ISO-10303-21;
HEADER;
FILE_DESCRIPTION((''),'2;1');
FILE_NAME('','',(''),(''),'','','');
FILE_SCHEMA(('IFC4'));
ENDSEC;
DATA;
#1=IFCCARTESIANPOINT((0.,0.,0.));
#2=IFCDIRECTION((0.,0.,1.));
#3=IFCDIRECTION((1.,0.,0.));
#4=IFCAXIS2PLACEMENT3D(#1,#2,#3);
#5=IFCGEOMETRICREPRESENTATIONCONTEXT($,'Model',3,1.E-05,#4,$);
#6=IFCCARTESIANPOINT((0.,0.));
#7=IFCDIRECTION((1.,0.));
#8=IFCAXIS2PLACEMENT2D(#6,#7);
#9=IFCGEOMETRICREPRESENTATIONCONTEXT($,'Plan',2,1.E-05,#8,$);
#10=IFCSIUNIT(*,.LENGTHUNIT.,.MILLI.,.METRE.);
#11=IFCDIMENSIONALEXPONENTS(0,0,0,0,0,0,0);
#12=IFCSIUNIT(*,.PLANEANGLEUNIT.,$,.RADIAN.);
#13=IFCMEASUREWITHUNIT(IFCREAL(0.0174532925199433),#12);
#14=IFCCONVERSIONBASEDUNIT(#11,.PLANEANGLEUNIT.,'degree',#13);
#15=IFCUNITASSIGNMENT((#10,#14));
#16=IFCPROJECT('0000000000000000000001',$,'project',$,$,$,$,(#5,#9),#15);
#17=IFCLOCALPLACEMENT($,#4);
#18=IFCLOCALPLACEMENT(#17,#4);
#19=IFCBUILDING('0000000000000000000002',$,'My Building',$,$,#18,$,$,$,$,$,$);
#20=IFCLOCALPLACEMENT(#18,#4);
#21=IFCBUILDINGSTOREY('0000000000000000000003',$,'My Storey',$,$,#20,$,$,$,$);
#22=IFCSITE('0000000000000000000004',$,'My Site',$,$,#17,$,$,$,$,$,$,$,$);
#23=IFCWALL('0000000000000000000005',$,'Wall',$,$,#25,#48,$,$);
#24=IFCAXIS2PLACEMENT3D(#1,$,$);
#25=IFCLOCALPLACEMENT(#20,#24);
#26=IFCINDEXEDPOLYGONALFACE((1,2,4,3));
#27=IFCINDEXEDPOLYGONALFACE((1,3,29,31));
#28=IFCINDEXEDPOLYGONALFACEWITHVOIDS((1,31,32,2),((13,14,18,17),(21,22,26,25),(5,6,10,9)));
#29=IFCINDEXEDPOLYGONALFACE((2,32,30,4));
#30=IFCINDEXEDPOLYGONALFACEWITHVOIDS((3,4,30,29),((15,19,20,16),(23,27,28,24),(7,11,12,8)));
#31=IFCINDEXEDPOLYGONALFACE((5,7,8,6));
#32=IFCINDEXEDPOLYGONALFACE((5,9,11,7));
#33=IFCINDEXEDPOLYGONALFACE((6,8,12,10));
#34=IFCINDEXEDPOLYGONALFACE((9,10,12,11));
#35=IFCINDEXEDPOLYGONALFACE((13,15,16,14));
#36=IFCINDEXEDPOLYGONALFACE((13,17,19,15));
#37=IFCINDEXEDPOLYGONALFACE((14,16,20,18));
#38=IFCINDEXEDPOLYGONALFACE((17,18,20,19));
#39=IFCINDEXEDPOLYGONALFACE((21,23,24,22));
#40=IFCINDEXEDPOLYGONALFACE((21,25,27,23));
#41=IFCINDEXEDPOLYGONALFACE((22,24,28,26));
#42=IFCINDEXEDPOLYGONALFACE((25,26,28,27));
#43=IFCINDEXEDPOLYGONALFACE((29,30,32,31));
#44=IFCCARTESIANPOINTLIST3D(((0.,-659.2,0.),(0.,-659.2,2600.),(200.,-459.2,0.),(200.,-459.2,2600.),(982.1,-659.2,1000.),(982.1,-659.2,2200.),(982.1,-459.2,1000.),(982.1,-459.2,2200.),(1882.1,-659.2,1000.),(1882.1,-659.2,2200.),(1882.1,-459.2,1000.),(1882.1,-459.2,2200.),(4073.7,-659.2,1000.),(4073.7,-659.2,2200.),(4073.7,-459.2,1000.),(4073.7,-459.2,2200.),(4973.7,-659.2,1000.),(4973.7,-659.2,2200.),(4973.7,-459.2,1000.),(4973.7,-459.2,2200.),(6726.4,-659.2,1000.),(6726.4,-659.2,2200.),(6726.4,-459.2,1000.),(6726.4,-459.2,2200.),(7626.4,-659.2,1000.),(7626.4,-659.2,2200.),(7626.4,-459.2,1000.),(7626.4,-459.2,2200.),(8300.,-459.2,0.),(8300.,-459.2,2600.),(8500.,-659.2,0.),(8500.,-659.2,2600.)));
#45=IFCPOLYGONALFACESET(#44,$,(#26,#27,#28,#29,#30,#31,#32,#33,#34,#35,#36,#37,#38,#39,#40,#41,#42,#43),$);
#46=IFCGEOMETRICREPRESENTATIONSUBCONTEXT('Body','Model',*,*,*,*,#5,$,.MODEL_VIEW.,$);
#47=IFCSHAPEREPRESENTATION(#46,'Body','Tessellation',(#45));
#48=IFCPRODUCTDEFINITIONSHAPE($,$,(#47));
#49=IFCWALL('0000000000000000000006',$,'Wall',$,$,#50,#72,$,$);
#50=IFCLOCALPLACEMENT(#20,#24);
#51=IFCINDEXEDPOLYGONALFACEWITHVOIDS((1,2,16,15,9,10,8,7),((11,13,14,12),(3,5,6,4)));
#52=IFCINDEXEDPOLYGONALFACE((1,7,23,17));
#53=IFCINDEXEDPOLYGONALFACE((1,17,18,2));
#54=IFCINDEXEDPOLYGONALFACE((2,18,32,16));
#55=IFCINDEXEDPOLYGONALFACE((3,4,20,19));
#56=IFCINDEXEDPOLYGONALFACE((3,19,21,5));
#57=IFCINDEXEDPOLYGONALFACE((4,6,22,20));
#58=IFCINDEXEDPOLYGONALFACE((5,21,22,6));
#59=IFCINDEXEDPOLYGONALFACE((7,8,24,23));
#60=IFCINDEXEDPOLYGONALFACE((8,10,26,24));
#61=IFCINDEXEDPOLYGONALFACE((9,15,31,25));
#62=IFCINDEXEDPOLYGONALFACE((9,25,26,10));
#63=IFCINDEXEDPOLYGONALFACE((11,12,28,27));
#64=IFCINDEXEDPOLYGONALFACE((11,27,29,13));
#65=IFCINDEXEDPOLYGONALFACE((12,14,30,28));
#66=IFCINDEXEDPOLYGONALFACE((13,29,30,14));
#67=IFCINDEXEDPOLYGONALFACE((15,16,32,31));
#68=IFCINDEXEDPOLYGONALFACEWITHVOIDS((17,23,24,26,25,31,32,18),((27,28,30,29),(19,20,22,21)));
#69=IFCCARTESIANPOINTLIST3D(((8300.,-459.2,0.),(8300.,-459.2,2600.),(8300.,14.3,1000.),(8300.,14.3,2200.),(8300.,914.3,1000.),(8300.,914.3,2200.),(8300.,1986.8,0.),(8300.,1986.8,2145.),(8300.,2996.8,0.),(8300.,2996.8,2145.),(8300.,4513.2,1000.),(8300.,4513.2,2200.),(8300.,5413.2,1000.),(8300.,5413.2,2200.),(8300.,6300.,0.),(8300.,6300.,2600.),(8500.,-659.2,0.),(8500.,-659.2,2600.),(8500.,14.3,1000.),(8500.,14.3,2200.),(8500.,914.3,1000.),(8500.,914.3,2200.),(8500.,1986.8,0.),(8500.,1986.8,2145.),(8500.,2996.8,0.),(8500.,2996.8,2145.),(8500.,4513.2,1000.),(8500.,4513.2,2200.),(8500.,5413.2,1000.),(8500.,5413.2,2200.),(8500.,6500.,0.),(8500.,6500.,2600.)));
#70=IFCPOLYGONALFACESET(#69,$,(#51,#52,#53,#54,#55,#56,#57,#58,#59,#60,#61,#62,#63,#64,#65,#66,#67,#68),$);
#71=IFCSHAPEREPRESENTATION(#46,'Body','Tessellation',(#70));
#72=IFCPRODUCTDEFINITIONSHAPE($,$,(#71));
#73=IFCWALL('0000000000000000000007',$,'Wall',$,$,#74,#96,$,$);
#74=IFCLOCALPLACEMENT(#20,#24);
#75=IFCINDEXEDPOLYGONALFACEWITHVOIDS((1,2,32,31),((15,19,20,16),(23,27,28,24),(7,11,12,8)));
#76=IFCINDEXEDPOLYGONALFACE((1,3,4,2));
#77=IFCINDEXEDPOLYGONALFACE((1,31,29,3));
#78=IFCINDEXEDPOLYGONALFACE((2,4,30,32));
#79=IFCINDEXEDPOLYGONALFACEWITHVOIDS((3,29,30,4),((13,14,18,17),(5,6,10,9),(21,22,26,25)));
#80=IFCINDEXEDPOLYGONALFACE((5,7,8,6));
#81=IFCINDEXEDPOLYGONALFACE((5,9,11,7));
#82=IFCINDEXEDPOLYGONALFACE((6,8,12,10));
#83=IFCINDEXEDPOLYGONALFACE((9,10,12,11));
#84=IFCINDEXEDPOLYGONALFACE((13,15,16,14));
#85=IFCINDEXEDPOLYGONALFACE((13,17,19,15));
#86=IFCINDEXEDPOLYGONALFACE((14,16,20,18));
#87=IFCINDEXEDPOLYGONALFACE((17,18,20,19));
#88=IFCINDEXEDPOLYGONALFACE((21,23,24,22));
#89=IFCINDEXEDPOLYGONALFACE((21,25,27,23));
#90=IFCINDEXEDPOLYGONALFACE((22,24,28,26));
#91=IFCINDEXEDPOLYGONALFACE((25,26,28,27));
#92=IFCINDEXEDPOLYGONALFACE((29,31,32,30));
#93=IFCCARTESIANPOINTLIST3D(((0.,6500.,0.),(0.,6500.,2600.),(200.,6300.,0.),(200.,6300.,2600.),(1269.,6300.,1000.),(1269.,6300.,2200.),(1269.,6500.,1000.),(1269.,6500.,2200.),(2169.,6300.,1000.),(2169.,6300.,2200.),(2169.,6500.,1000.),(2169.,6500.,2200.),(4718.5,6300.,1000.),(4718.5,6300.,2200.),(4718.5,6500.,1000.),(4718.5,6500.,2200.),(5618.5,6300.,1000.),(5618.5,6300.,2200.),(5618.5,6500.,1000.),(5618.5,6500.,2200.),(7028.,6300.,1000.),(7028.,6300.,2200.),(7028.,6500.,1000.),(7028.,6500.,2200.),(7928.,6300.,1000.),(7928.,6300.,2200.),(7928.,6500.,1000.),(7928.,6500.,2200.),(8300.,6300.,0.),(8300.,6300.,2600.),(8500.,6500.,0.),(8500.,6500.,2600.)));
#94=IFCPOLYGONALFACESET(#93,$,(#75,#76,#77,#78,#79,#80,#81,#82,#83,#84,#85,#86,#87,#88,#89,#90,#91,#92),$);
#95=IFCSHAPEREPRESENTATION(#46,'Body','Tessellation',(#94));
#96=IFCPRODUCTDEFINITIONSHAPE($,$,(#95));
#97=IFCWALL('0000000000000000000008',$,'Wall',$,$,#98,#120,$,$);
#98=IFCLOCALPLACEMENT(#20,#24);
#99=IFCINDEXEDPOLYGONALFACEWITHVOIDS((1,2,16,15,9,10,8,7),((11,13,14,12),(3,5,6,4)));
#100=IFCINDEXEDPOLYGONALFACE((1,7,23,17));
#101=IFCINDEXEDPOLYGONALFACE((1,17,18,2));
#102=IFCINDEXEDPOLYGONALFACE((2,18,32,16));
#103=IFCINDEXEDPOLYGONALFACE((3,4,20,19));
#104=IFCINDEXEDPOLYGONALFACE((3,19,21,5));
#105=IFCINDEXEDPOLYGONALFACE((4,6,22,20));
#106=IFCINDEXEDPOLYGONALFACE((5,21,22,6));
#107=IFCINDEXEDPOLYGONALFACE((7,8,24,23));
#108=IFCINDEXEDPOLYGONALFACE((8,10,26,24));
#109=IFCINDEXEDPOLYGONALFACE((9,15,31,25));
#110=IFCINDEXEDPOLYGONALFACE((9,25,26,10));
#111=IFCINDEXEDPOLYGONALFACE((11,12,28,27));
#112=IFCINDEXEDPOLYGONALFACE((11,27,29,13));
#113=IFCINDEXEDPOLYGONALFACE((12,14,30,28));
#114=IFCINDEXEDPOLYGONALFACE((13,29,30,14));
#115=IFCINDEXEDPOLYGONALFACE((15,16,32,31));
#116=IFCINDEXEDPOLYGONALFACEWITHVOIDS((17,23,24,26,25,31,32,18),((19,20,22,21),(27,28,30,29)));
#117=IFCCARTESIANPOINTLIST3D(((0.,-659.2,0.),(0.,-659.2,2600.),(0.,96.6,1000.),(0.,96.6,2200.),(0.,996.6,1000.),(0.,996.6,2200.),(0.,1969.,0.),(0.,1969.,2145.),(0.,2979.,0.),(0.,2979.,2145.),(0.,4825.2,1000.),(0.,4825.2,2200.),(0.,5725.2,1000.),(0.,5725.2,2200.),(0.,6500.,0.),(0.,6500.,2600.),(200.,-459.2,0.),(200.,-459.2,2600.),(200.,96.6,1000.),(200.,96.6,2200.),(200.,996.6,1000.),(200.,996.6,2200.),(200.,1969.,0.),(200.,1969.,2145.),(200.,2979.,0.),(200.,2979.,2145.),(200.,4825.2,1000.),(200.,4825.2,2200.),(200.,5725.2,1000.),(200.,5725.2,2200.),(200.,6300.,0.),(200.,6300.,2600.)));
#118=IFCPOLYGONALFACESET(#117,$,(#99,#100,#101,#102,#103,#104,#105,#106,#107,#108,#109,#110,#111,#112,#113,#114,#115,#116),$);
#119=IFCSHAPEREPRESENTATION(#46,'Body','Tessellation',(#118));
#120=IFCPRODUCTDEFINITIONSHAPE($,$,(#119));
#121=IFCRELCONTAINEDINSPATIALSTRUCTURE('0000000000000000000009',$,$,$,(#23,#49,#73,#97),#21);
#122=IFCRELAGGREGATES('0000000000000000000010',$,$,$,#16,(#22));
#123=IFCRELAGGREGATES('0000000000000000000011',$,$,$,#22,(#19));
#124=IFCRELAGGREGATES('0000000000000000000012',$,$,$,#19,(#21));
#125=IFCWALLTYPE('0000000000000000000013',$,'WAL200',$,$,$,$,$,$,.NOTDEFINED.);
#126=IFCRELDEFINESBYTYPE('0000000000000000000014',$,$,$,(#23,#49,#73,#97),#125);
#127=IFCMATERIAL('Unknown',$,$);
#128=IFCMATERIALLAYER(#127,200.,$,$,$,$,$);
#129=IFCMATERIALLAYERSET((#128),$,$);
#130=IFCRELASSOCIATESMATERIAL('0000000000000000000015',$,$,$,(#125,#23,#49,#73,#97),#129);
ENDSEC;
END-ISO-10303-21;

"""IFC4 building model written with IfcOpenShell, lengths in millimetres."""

from ifc_helpers import new_model, entity, si_unit, converted_unit, frame, origin_with_axes, origin_2d_with_axis, place, context, subcontext, project, spatial, line, indexed_curve, outline, extrude, source, transform, mapped, material, layer, layer_set, layer_usage, type_object, element, save


model = new_model("IFC4")

# Units and contexts
model_context = context("Model", 3, precision=1e-05, world=origin_with_axes())
plan_context = context("Plan", 2, precision=1e-05, world=origin_2d_with_axis())
body_context = subcontext(model_context, "Body", "Model", "MODEL_VIEW")
ifc_project = project(units=[si_unit("LENGTHUNIT", "METRE", prefix="MILLI"), converted_unit("PLANEANGLEUNIT", "degree", entity("IfcReal", 0.0174532925199433), si_unit("PLANEANGLEUNIT", "RADIAN"), dimensions=[0, 0, 0, 0, 0, 0, 0])], contexts=[model_context, plan_context])

# Site, building, storey
site_placement = place(None, origin_with_axes())
site = spatial("IfcSite", under=ifc_project, at=site_placement, Name="My Site")
building_placement = place(site_placement, origin_with_axes())
building = spatial("IfcBuilding", under=site, at=building_placement, Name="My Building")
storey_placement = place(building_placement, origin_with_axes())
storey = spatial("IfcBuildingStorey", under=building, at=storey_placement, Name="My Storey")

# Shared definitions
ifc_material = material(Name="Unknown")

# Shared definitions
shared_shape_1 = source(origin_with_axes(), body_context, "Body", "SweptSolid", [
    extrude(outline(indexed_curve([(0.0, 0.0), (1010.0, 0.0), (1010.0, 2145.0), (0.0, 2145.0)], segments=[line(1, 2, 3, 4, 1)])), frame((0.0, -600.0, 0.0), z_axis=(0.0, -1.0, 0.0), x_axis=(1.0, 0.0, 0.0)), (0.0, 0.0, -1.0), 1200.0),
])

# Walls, openings
ifc_layer_1 = layer(ifc_material, 200.0)
ifc_layer_set_1 = layer_set([ifc_layer_1])
ifc_layer_usage_1 = layer_usage(ifc_layer_set_1, "AXIS2", "POSITIVE", 0.0)
wall_type_1 = type_object("IfcWallType", Name="WAL200", PredefinedType="NOTDEFINED", material=ifc_layer_set_1)
wall_1_placement = place(storey_placement, frame((0.0, -659.2, 0.0), z_axis=(0.0, 0.0, 1.0), x_axis=(1.0, 0.0, 0.0)))
wall_1 = element("IfcWall", 1, at=wall_1_placement, inside=storey, type_object=wall_type_1, material=ifc_layer_usage_1, Name="Wall", context=body_context, shape_type="SweptSolid", body=[
    extrude(outline(indexed_curve([(0.0, 0.0), (200.0, 200.0), (8300.0, 200.0), (8500.0, 0.0)], segments=[line(1, 2, 3, 4, 1)])), origin_with_axes(), (0.0, 0.0, 1.0), 2600.0),
])
shared_shape_2 = source(origin_with_axes(), body_context, "Body", "SweptSolid", [
    extrude(outline(indexed_curve([(0.0, 0.0), (900.0, 0.0), (900.0, 1200.0), (0.0, 1200.0)], segments=[line(1, 2, 3, 4, 1)])), frame((0.0, -600.0, 0.0), z_axis=(0.0, -1.0, 0.0), x_axis=(1.0, 0.0, 0.0)), (0.0, 0.0, -1.0), 1200.0),
])
opening_1_placement = place(wall_1_placement, frame((6726.4, 0.0, 1000.0), z_axis=(0.0, 0.0, 1.0), x_axis=(1.0, 0.0, 0.0)))
element("IfcOpeningElement", 2, at=opening_1_placement, cuts=wall_1, PredefinedType="OPENING", context=body_context, shape_type="MappedRepresentation", body=[
    mapped(shared_shape_2, transform((0.0, 0.0, 0.0), x_axis=(1.0, 0.0, 0.0), y_axis=(0.0, 1.0, 0.0), z_axis=(0.0, 0.0, 1.0), scale=1.0)),
])
opening_2_placement = place(wall_1_placement, frame((4073.7, 0.0, 1000.0), z_axis=(0.0, 0.0, 1.0), x_axis=(1.0, 0.0, 0.0)))
element("IfcOpeningElement", 3, at=opening_2_placement, cuts=wall_1, PredefinedType="OPENING", context=body_context, shape_type="MappedRepresentation", body=[
    mapped(shared_shape_2, transform((0.0, 0.0, 0.0), x_axis=(1.0, 0.0, 0.0), y_axis=(0.0, 1.0, 0.0), z_axis=(0.0, 0.0, 1.0), scale=1.0)),
])
opening_3_placement = place(wall_1_placement, frame((982.1, 0.0, 1000.0), z_axis=(0.0, 0.0, 1.0), x_axis=(1.0, 0.0, 0.0)))
element("IfcOpeningElement", 4, at=opening_3_placement, cuts=wall_1, PredefinedType="OPENING", context=body_context, shape_type="MappedRepresentation", body=[
    mapped(shared_shape_2, transform((0.0, 0.0, 0.0), x_axis=(1.0, 0.0, 0.0), y_axis=(0.0, 1.0, 0.0), z_axis=(0.0, 0.0, 1.0), scale=1.0)),
])
ifc_layer_usage_2 = layer_usage(ifc_layer_set_1, "AXIS2", "POSITIVE", 0.0)
wall_2_placement = place(storey_placement, frame((8500.0, -659.2, 0.0), z_axis=(0.0, 0.0, 1.0), x_axis=(0.0, 1.0, 0.0)))
wall_2 = element("IfcWall", 5, at=wall_2_placement, inside=storey, type_object=wall_type_1, material=ifc_layer_usage_2, Name="Wall", context=body_context, shape_type="SweptSolid", body=[
    extrude(outline(indexed_curve([(0.0, 0.0), (200.0, 200.0), (6959.2, 200.0), (7159.2, 0.0)], segments=[line(1, 2, 3, 4, 1)])), origin_with_axes(), (0.0, 0.0, 1.0), 2600.0),
])
opening_4_placement = place(wall_2_placement, frame((5172.4, 0.0, 1000.0), z_axis=(0.0, 0.0, 1.0), x_axis=(1.0, 0.0, 0.0)))
element("IfcOpeningElement", 6, at=opening_4_placement, cuts=wall_2, PredefinedType="OPENING", context=body_context, shape_type="MappedRepresentation", body=[
    mapped(shared_shape_2, transform((0.0, 0.0, 0.0), x_axis=(1.0, 0.0, 0.0), y_axis=(0.0, 1.0, 0.0), z_axis=(0.0, 0.0, 1.0), scale=1.0)),
])
opening_5_placement = place(wall_2_placement, frame((2646.0, 0.0, 0.0), z_axis=(0.0, 0.0, 1.0), x_axis=(1.0, 0.0, 0.0)))
element("IfcOpeningElement", 7, at=opening_5_placement, cuts=wall_2, PredefinedType="OPENING", context=body_context, shape_type="MappedRepresentation", body=[
    mapped(shared_shape_1, transform((0.0, 0.0, 0.0), x_axis=(1.0, 0.0, 0.0), y_axis=(0.0, 1.0, 0.0), z_axis=(0.0, 0.0, 1.0), scale=1.0)),
])
opening_6_placement = place(wall_2_placement, frame((673.5, 0.0, 1000.0), z_axis=(0.0, 0.0, 1.0), x_axis=(1.0, 0.0, 0.0)))
element("IfcOpeningElement", 8, at=opening_6_placement, cuts=wall_2, PredefinedType="OPENING", context=body_context, shape_type="MappedRepresentation", body=[
    mapped(shared_shape_2, transform((0.0, 0.0, 0.0), x_axis=(1.0, 0.0, 0.0), y_axis=(0.0, 1.0, 0.0), z_axis=(0.0, 0.0, 1.0), scale=1.0)),
])
ifc_layer_usage_3 = layer_usage(ifc_layer_set_1, "AXIS2", "POSITIVE", 0.0)
wall_3_placement = place(storey_placement, frame((8500.0, 6500.0, 0.0), z_axis=(0.0, 0.0, 1.0), x_axis=(-1.0, 0.0, 0.0)))
wall_3 = element("IfcWall", 9, at=wall_3_placement, inside=storey, type_object=wall_type_1, material=ifc_layer_usage_3, Name="Wall", context=body_context, shape_type="SweptSolid", body=[
    extrude(outline(indexed_curve([(0.0, 0.0), (200.0, 200.0), (8300.0, 200.0), (8500.0, 0.0)], segments=[line(1, 2, 3, 4, 1)])), origin_with_axes(), (0.0, 0.0, 1.0), 2600.0),
])
opening_7_placement = place(wall_3_placement, frame((6331.0, 0.0, 1000.0), z_axis=(0.0, 0.0, 1.0), x_axis=(1.0, 0.0, 0.0)))
element("IfcOpeningElement", 10, at=opening_7_placement, cuts=wall_3, PredefinedType="OPENING", context=body_context, shape_type="MappedRepresentation", body=[
    mapped(shared_shape_2, transform((0.0, 0.0, 0.0), x_axis=(1.0, 0.0, 0.0), y_axis=(0.0, 1.0, 0.0), z_axis=(0.0, 0.0, 1.0), scale=1.0)),
])
opening_8_placement = place(wall_3_placement, frame((2881.5, 0.0, 1000.0), z_axis=(0.0, 0.0, 1.0), x_axis=(1.0, 0.0, 0.0)))
element("IfcOpeningElement", 11, at=opening_8_placement, cuts=wall_3, PredefinedType="OPENING", context=body_context, shape_type="MappedRepresentation", body=[
    mapped(shared_shape_2, transform((0.0, 0.0, 0.0), x_axis=(1.0, 0.0, 0.0), y_axis=(0.0, 1.0, 0.0), z_axis=(0.0, 0.0, 1.0), scale=1.0)),
])
opening_9_placement = place(wall_3_placement, frame((572.0, 0.0, 1000.0), z_axis=(0.0, 0.0, 1.0), x_axis=(1.0, 0.0, 0.0)))
element("IfcOpeningElement", 12, at=opening_9_placement, cuts=wall_3, PredefinedType="OPENING", context=body_context, shape_type="MappedRepresentation", body=[
    mapped(shared_shape_2, transform((0.0, 0.0, 0.0), x_axis=(1.0, 0.0, 0.0), y_axis=(0.0, 1.0, 0.0), z_axis=(0.0, 0.0, 1.0), scale=1.0)),
])
ifc_layer_usage_4 = layer_usage(ifc_layer_set_1, "AXIS2", "POSITIVE", 0.0)
wall_4_placement = place(storey_placement, frame((0.0, 6500.0, 0.0), z_axis=(0.0, 0.0, 1.0), x_axis=(0.0, -1.0, 0.0)))
wall_4 = element("IfcWall", 13, at=wall_4_placement, inside=storey, type_object=wall_type_1, material=ifc_layer_usage_4, Name="Wall", context=body_context, shape_type="SweptSolid", body=[
    extrude(outline(indexed_curve([(0.0, 0.0), (200.0, 200.0), (6959.2, 200.0), (7159.2, 0.0)], segments=[line(1, 2, 3, 4, 1)])), origin_with_axes(), (0.0, 0.0, 1.0), 2600.0),
])
opening_10_placement = place(wall_4_placement, frame((774.8, 0.0, 1000.0), z_axis=(0.0, 0.0, 1.0), x_axis=(1.0, 0.0, 0.0)))
element("IfcOpeningElement", 14, at=opening_10_placement, cuts=wall_4, PredefinedType="OPENING", context=body_context, shape_type="MappedRepresentation", body=[
    mapped(shared_shape_2, transform((0.0, 0.0, 0.0), x_axis=(1.0, 0.0, 0.0), y_axis=(0.0, 1.0, 0.0), z_axis=(0.0, 0.0, 1.0), scale=1.0)),
])
opening_11_placement = place(wall_4_placement, frame((4531.0, 200.0, 0.0), z_axis=(0.0, 0.0, 1.0), x_axis=(-1.0, 0.0, 0.0)))
element("IfcOpeningElement", 15, at=opening_11_placement, cuts=wall_4, PredefinedType="OPENING", context=body_context, shape_type="MappedRepresentation", body=[
    mapped(shared_shape_1, transform((0.0, 0.0, 0.0), x_axis=(1.0, 0.0, 0.0), y_axis=(0.0, 1.0, 0.0), z_axis=(0.0, 0.0, 1.0), scale=1.0)),
])
opening_12_placement = place(wall_4_placement, frame((5503.4, 0.0, 1000.0), z_axis=(0.0, 0.0, 1.0), x_axis=(1.0, 0.0, 0.0)))
element("IfcOpeningElement", 16, at=opening_12_placement, cuts=wall_4, PredefinedType="OPENING", context=body_context, shape_type="MappedRepresentation", body=[
    mapped(shared_shape_2, transform((0.0, 0.0, 0.0), x_axis=(1.0, 0.0, 0.0), y_axis=(0.0, 1.0, 0.0), z_axis=(0.0, 0.0, 1.0), scale=1.0)),
])

save(model, "model.ifc")
